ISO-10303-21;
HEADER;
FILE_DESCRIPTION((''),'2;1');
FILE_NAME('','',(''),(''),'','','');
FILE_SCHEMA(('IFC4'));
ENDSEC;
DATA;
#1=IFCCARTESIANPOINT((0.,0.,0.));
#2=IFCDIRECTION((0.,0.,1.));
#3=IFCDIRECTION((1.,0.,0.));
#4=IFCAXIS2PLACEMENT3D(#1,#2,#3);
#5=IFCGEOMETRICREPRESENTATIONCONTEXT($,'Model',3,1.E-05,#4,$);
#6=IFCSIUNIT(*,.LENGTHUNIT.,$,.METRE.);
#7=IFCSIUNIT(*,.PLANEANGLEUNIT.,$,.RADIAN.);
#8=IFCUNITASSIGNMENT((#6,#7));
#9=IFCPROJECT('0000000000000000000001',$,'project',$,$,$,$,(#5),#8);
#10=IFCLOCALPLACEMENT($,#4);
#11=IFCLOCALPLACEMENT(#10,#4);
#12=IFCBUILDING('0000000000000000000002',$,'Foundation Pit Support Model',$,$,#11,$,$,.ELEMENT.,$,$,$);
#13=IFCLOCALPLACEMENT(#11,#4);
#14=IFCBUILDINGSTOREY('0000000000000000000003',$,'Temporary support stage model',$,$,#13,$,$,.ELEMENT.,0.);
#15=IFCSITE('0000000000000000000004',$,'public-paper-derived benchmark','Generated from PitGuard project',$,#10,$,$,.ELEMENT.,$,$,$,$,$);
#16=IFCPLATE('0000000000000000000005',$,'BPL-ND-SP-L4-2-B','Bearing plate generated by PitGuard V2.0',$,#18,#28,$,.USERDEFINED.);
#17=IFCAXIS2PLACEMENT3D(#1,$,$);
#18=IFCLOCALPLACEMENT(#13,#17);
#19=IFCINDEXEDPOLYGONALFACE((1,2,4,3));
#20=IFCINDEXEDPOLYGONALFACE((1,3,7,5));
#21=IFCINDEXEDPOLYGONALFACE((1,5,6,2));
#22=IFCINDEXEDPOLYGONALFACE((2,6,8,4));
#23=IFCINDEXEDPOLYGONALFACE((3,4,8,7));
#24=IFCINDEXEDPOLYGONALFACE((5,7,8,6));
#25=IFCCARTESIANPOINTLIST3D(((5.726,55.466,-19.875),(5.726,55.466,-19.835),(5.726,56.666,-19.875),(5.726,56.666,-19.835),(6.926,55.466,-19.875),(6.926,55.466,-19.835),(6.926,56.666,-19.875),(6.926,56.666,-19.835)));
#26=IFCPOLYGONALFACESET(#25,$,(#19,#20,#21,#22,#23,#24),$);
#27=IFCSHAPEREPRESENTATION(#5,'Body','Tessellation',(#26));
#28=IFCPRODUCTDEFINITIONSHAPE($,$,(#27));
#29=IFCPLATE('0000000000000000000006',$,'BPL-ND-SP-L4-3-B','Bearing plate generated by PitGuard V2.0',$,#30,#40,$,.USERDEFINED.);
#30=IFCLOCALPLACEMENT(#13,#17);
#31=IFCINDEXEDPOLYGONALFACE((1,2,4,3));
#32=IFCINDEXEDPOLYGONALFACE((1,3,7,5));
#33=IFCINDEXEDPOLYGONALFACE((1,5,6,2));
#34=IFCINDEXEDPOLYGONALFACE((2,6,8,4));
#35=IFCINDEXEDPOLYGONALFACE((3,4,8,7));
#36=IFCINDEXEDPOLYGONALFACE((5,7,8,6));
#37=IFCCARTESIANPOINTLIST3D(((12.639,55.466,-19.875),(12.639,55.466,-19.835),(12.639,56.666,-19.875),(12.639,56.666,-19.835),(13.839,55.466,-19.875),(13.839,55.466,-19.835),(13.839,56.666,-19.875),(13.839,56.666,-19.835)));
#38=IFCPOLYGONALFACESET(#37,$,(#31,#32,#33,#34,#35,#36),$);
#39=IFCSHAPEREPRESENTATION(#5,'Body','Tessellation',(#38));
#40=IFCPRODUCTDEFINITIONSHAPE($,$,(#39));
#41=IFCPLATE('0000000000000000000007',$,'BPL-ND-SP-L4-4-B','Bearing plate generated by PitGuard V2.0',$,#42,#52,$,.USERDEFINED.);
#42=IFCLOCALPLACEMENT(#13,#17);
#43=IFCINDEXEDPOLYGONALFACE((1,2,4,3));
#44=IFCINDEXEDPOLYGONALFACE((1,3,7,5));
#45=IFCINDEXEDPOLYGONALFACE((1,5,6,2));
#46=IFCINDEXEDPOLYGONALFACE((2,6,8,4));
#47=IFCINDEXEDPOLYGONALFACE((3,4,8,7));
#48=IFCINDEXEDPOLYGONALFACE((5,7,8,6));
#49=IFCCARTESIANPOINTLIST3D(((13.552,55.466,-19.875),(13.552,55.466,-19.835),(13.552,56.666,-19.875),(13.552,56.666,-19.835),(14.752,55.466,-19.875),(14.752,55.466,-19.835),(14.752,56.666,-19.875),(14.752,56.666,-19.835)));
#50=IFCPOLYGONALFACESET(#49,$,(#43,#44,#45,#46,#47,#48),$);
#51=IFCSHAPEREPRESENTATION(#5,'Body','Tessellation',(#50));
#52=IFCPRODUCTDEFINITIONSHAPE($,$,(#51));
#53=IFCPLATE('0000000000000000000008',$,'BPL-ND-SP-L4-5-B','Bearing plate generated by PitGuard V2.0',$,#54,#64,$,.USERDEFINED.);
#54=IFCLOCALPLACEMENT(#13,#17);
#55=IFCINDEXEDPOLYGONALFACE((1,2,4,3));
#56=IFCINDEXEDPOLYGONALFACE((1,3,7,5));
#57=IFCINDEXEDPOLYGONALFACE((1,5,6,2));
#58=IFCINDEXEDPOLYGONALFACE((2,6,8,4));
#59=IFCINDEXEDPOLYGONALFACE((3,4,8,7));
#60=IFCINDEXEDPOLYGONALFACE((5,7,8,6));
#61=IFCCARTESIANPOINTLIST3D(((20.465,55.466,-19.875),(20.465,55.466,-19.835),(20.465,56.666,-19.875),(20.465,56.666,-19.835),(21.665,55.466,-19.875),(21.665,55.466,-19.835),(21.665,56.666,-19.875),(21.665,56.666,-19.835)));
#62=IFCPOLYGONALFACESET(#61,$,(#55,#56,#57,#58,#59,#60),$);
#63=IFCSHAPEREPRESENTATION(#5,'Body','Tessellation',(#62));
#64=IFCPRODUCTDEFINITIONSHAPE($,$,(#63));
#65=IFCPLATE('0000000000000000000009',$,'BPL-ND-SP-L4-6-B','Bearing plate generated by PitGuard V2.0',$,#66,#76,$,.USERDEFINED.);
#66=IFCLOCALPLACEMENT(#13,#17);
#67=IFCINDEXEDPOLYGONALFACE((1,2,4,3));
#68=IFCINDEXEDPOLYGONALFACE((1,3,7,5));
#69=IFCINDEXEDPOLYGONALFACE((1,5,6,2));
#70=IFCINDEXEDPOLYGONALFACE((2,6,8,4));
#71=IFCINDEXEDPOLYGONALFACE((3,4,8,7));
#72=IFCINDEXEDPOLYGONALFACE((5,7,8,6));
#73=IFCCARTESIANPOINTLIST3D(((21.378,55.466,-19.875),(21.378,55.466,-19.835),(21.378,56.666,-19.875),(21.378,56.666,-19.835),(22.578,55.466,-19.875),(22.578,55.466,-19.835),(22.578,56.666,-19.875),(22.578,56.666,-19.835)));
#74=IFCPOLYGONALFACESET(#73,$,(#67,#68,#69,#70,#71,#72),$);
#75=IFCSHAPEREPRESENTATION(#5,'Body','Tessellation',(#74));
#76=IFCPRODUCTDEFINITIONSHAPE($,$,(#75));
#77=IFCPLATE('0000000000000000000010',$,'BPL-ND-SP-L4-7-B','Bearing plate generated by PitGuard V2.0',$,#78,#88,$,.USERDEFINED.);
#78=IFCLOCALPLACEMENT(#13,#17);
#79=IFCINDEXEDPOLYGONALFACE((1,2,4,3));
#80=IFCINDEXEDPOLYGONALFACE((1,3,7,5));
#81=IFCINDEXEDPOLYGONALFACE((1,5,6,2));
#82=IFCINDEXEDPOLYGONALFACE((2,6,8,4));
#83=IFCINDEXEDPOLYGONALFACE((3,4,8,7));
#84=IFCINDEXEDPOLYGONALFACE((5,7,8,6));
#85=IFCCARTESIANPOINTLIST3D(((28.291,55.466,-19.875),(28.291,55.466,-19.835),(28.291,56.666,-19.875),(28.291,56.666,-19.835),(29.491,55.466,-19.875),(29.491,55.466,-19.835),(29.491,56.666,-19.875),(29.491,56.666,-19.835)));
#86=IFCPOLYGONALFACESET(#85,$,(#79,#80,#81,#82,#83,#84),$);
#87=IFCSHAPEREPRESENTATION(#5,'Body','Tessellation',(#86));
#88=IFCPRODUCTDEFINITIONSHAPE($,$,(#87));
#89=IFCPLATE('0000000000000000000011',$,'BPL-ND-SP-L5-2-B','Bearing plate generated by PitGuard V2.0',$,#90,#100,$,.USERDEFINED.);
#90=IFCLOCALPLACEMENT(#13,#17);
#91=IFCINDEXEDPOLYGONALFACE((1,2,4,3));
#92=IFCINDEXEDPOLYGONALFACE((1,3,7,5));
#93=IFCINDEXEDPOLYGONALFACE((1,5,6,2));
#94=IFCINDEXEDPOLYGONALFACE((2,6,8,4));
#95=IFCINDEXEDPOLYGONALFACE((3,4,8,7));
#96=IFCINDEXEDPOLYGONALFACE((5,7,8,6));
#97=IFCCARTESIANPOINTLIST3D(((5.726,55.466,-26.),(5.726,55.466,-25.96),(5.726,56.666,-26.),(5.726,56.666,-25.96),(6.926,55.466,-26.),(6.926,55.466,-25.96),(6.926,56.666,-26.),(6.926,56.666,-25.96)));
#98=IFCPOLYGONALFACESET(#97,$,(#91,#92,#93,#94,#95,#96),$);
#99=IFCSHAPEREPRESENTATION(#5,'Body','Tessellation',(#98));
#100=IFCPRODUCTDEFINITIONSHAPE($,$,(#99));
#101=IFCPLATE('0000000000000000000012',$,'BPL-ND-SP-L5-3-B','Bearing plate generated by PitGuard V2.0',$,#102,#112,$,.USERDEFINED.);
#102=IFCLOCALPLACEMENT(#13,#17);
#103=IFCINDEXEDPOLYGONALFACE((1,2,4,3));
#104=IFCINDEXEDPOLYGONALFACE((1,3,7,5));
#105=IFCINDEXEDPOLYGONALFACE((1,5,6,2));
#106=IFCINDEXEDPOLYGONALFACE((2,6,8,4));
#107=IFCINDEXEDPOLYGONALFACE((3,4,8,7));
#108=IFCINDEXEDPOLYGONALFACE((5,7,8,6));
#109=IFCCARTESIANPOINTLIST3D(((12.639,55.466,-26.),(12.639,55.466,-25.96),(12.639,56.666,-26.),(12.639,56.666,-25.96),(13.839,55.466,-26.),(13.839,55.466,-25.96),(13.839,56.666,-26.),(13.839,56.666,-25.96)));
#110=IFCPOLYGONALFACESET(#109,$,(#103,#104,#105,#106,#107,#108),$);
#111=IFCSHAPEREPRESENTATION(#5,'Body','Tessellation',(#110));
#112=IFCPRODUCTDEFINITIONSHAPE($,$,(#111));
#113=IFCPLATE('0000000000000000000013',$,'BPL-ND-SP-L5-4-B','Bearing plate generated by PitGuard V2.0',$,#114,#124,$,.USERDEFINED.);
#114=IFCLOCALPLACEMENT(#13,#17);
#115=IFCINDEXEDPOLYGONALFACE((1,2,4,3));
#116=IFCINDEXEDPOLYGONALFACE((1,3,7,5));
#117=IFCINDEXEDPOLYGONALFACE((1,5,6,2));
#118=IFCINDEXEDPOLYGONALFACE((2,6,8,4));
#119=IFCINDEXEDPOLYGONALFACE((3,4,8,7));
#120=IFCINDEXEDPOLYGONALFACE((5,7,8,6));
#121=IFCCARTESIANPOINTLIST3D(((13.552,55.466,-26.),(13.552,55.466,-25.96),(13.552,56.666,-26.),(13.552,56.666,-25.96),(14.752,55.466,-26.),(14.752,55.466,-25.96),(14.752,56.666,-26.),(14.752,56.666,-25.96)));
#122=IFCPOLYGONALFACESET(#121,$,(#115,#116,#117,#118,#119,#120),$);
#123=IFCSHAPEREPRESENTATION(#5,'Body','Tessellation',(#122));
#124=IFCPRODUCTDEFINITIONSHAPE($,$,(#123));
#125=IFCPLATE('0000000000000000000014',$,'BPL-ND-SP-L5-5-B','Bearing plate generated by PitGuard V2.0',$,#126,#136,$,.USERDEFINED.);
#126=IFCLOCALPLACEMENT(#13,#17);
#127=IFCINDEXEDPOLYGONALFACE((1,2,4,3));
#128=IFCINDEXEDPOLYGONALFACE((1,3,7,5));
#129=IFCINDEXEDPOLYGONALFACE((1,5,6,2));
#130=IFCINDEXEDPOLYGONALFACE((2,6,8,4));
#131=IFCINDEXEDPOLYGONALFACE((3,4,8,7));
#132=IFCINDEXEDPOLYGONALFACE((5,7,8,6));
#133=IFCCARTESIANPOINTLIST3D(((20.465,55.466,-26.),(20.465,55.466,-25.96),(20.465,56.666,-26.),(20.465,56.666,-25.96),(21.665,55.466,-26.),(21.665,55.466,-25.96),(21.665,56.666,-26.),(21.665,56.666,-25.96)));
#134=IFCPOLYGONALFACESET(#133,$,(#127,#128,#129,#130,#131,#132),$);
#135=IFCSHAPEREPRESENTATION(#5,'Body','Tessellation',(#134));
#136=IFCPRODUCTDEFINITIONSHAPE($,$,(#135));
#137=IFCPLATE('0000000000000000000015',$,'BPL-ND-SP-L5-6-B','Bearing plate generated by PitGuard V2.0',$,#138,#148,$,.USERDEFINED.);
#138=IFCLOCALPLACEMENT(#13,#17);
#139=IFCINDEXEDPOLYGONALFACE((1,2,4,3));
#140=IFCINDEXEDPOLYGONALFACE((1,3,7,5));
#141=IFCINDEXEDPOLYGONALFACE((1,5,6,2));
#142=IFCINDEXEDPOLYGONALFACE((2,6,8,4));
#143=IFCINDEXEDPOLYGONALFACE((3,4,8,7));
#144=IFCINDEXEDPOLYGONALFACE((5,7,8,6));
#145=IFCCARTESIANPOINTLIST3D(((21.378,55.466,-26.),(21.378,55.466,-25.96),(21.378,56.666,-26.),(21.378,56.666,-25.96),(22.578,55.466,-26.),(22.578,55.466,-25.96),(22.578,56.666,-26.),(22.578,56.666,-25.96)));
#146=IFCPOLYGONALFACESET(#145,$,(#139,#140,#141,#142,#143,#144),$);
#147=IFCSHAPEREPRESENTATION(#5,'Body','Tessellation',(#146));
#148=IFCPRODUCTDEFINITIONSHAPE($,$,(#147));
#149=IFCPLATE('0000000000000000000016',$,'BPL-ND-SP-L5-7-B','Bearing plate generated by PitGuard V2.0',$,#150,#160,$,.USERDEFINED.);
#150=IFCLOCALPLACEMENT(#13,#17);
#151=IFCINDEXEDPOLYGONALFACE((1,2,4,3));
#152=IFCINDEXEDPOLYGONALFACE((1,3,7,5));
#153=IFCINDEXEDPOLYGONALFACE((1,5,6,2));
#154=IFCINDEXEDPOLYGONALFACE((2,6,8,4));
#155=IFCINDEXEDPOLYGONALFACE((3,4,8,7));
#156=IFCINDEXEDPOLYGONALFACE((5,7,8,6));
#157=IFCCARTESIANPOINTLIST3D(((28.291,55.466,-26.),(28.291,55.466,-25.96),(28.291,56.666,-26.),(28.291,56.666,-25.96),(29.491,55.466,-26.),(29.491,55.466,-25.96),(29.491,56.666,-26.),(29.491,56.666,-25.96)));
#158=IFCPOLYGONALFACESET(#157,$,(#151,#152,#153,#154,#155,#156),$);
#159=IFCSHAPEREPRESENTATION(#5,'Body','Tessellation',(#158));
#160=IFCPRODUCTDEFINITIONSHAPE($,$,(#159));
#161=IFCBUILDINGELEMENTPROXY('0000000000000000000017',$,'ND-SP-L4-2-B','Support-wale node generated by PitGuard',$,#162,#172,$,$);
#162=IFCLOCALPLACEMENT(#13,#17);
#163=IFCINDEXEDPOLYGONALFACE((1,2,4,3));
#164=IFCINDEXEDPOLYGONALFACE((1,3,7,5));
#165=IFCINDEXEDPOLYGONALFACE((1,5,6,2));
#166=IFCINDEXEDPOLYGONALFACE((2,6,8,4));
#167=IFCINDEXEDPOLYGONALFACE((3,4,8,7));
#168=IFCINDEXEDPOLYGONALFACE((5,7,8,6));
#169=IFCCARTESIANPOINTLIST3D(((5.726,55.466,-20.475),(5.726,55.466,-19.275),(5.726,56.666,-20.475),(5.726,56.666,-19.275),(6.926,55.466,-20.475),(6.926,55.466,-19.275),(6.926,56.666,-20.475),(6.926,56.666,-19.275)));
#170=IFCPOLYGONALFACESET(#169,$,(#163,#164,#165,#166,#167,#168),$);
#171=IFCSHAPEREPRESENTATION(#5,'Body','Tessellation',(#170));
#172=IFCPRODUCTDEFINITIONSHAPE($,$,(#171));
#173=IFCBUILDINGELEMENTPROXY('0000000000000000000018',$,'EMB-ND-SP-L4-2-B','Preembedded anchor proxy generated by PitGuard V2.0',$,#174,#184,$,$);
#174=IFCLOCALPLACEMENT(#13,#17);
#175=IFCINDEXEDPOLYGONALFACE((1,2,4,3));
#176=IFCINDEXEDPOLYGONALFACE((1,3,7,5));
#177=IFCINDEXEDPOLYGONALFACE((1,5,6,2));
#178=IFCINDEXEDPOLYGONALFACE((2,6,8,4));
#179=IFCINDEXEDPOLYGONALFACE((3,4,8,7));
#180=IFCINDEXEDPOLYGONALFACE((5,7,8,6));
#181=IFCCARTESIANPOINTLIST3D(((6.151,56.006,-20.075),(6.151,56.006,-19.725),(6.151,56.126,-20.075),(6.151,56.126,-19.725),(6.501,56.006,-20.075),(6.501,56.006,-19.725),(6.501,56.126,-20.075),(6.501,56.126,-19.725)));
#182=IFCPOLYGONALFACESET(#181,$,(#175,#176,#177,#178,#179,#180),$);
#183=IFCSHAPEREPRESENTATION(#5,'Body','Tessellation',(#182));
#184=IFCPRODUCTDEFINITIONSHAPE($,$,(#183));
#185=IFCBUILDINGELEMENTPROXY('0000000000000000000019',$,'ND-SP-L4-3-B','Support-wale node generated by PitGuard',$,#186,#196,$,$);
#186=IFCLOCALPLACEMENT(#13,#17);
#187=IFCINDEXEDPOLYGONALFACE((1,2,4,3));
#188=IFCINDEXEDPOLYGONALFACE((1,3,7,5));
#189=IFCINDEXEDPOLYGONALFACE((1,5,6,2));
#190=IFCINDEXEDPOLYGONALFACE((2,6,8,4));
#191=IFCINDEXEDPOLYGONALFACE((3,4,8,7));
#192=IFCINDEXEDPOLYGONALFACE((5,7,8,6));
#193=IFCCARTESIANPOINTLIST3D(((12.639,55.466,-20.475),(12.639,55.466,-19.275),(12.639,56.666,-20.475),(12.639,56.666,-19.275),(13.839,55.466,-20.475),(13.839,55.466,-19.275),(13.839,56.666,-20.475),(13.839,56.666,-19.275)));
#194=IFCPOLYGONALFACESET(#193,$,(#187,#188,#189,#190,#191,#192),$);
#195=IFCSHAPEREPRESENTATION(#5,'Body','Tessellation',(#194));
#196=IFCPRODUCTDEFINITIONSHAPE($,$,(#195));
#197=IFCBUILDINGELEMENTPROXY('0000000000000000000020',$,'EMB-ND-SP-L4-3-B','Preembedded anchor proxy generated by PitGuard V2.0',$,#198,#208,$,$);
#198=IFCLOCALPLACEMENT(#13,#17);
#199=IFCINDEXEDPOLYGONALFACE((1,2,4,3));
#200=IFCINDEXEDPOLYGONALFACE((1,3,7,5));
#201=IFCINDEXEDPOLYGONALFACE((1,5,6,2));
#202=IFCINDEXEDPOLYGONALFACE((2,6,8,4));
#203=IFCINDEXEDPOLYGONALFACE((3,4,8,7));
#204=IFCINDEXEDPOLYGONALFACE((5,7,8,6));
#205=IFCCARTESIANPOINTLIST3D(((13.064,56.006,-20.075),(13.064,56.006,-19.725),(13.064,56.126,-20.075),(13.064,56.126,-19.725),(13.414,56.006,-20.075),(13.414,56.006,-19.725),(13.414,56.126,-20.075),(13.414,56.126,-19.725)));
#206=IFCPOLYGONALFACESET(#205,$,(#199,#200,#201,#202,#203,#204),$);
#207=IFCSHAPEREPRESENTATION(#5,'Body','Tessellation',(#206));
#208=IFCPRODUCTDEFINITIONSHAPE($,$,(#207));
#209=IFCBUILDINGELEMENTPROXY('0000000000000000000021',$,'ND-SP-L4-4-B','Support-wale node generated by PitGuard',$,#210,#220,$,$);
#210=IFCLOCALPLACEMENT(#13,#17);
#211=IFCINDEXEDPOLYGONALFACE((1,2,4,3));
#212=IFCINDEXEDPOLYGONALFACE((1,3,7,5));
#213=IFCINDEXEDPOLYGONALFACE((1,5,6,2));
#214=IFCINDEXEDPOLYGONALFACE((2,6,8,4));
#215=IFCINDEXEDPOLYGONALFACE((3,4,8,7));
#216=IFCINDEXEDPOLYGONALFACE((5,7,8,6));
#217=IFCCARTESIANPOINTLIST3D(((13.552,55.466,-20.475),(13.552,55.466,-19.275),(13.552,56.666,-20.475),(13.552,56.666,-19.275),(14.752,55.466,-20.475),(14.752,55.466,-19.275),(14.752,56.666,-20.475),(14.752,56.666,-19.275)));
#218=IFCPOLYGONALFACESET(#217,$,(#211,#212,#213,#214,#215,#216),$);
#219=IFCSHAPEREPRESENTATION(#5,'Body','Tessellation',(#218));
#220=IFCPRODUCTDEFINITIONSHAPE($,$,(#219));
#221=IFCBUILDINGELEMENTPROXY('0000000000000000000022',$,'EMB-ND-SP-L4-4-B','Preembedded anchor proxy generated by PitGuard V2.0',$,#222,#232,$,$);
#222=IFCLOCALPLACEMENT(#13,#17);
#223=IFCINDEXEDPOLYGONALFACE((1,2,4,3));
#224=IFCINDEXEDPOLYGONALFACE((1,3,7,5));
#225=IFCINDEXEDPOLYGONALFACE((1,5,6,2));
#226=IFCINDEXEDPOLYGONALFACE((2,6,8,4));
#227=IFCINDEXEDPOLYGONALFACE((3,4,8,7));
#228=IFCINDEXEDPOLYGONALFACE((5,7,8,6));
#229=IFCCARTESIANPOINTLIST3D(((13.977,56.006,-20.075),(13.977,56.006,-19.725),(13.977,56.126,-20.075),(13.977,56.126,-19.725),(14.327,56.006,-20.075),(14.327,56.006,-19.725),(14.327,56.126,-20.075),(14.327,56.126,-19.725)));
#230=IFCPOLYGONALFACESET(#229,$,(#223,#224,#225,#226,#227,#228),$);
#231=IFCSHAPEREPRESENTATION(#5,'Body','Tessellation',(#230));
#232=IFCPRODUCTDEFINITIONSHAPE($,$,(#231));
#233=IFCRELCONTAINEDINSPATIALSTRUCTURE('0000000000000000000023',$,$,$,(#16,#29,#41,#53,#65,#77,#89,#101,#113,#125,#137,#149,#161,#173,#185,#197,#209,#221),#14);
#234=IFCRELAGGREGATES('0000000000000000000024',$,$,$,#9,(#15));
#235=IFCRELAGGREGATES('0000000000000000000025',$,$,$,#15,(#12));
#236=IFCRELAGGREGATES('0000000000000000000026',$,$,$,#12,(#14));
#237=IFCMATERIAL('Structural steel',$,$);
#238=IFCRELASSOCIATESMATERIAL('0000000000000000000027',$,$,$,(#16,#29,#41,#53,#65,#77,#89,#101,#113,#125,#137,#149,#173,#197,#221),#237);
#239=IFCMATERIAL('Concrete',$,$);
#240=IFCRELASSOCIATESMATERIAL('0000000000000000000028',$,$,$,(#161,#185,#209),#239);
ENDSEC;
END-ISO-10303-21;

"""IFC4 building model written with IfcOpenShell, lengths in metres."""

from ifc_helpers import new_model, si_unit, frame, origin_with_axes, origin_2d, place, context, project, spatial, rectangle, extrude, material, element, save


model = new_model("IFC4")

# Units and contexts
model_context = context("Model", 3, precision=1e-05, world=origin_with_axes())
ifc_project = project(units=[si_unit("LENGTHUNIT", "METRE"), si_unit("PLANEANGLEUNIT", "RADIAN")], contexts=[model_context])

# Site, building, storey
site_placement = place(None, origin_with_axes())
site = spatial("IfcSite", under=ifc_project, at=site_placement, Name="public-paper-derived benchmark", Description="Generated from PitGuard project", CompositionType="ELEMENT")
building_placement = place(site_placement, origin_with_axes())
building = spatial("IfcBuilding", under=site, at=building_placement, Name="Foundation Pit Support Model", CompositionType="ELEMENT")
storey_placement = place(building_placement, origin_with_axes())
storey = spatial("IfcBuildingStorey", under=building, at=storey_placement, Name="Temporary support stage model", CompositionType="ELEMENT", Elevation=0.0)

# Plates
ifc_material_1 = material(Name="Structural steel")
for number, where, z_axis, x_axis, name in (
    (1, (6.326, 56.066, -19.875), (0.0, 0.0, 1.0), (1.0, 0.0, 0.0), "BPL-ND-SP-L4-2-B"),
    (2, (13.239, 56.066, -19.875), (0.0, 0.0, 1.0), (1.0, 0.0, 0.0), "BPL-ND-SP-L4-3-B"),
    (3, (14.152, 56.066, -19.875), (0.0, 0.0, 1.0), (1.0, 0.0, 0.0), "BPL-ND-SP-L4-4-B"),
    (4, (21.065, 56.066, -19.875), (0.0, 0.0, 1.0), (1.0, 0.0, 0.0), "BPL-ND-SP-L4-5-B"),
    (5, (21.978, 56.066, -19.875), (0.0, 0.0, 1.0), (1.0, 0.0, 0.0), "BPL-ND-SP-L4-6-B"),
    (6, (28.891, 56.066, -19.875), (0.0, 0.0, 1.0), (1.0, 0.0, 0.0), "BPL-ND-SP-L4-7-B"),
    (7, (6.326, 56.066, -26.0), (0.0, 0.0, 1.0), (1.0, 0.0, 0.0), "BPL-ND-SP-L5-2-B"),
    (8, (13.239, 56.066, -26.0), (0.0, 0.0, 1.0), (1.0, 0.0, 0.0), "BPL-ND-SP-L5-3-B"),
    (9, (14.152, 56.066, -26.0), (0.0, 0.0, 1.0), (1.0, 0.0, 0.0), "BPL-ND-SP-L5-4-B"),
    (10, (21.065, 56.066, -26.0), (0.0, 0.0, 1.0), (1.0, 0.0, 0.0), "BPL-ND-SP-L5-5-B"),
    (11, (21.978, 56.066, -26.0), (0.0, 0.0, 1.0), (1.0, 0.0, 0.0), "BPL-ND-SP-L5-6-B"),
    (12, (28.891, 56.066, -26.0), (0.0, 0.0, 1.0), (1.0, 0.0, 0.0), "BPL-ND-SP-L5-7-B"),
):
    element("IfcPlate", number, at=place(storey_placement, frame(where, z_axis=z_axis, x_axis=x_axis)), inside=storey, material=ifc_material_1, Name=name, Description="Bearing plate generated by PitGuard V2.0", PredefinedType="USERDEFINED", context=model_context, shape_type="SweptSolid", body=[
        extrude(rectangle(XDim=1.2, YDim=1.2, at=origin_2d()), origin_with_axes(), (0.0, 0.0, 1.0), 0.04),
    ])

# Building element proxies
ifc_material_2 = material(Name="Concrete")
proxy_1_placement = place(storey_placement, frame((6.326, 56.066, -20.475), z_axis=(0.0, 0.0, 1.0), x_axis=(1.0, 0.0, 0.0)))
element("IfcBuildingElementProxy", 13, at=proxy_1_placement, inside=storey, material=ifc_material_2, Name="ND-SP-L4-2-B", Description="Support-wale node generated by PitGuard", context=model_context, shape_type="SweptSolid", body=[
    extrude(rectangle(XDim=1.2, YDim=1.2, at=origin_2d()), origin_with_axes(), (0.0, 0.0, 1.0), 1.2),
])
proxy_2_placement = place(storey_placement, frame((6.326, 56.066, -20.075), z_axis=(0.0, 0.0, 1.0), x_axis=(1.0, 0.0, 0.0)))
element("IfcBuildingElementProxy", 14, at=proxy_2_placement, inside=storey, material=ifc_material_1, Name="EMB-ND-SP-L4-2-B", Description="Preembedded anchor proxy generated by PitGuard V2.0", context=model_context, shape_type="SweptSolid", body=[
    extrude(rectangle(XDim=0.35, YDim=0.12, at=origin_2d()), origin_with_axes(), (0.0, 0.0, 1.0), 0.35),
])
proxy_3_placement = place(storey_placement, frame((13.239, 56.066, -20.475), z_axis=(0.0, 0.0, 1.0), x_axis=(1.0, 0.0, 0.0)))
element("IfcBuildingElementProxy", 15, at=proxy_3_placement, inside=storey, material=ifc_material_2, Name="ND-SP-L4-3-B", Description="Support-wale node generated by PitGuard", context=model_context, shape_type="SweptSolid", body=[
    extrude(rectangle(XDim=1.2, YDim=1.2, at=origin_2d()), origin_with_axes(), (0.0, 0.0, 1.0), 1.2),
])
proxy_4_placement = place(storey_placement, frame((13.239, 56.066, -20.075), z_axis=(0.0, 0.0, 1.0), x_axis=(1.0, 0.0, 0.0)))
element("IfcBuildingElementProxy", 16, at=proxy_4_placement, inside=storey, material=ifc_material_1, Name="EMB-ND-SP-L4-3-B", Description="Preembedded anchor proxy generated by PitGuard V2.0", context=model_context, shape_type="SweptSolid", body=[
    extrude(rectangle(XDim=0.35, YDim=0.12, at=origin_2d()), origin_with_axes(), (0.0, 0.0, 1.0), 0.35),
])
proxy_5_placement = place(storey_placement, frame((14.152, 56.066, -20.475), z_axis=(0.0, 0.0, 1.0), x_axis=(1.0, 0.0, 0.0)))
element("IfcBuildingElementProxy", 17, at=proxy_5_placement, inside=storey, material=ifc_material_2, Name="ND-SP-L4-4-B", Description="Support-wale node generated by PitGuard", context=model_context, shape_type="SweptSolid", body=[
    extrude(rectangle(XDim=1.2, YDim=1.2, at=origin_2d()), origin_with_axes(), (0.0, 0.0, 1.0), 1.2),
])
proxy_6_placement = place(storey_placement, frame((14.152, 56.066, -20.075), z_axis=(0.0, 0.0, 1.0), x_axis=(1.0, 0.0, 0.0)))
element("IfcBuildingElementProxy", 18, at=proxy_6_placement, inside=storey, material=ifc_material_1, Name="EMB-ND-SP-L4-4-B", Description="Preembedded anchor proxy generated by PitGuard V2.0", context=model_context, shape_type="SweptSolid", body=[
    extrude(rectangle(XDim=0.35, YDim=0.12, at=origin_2d()), origin_with_axes(), (0.0, 0.0, 1.0), 0.35),
])

save(model, "model.ifc")
